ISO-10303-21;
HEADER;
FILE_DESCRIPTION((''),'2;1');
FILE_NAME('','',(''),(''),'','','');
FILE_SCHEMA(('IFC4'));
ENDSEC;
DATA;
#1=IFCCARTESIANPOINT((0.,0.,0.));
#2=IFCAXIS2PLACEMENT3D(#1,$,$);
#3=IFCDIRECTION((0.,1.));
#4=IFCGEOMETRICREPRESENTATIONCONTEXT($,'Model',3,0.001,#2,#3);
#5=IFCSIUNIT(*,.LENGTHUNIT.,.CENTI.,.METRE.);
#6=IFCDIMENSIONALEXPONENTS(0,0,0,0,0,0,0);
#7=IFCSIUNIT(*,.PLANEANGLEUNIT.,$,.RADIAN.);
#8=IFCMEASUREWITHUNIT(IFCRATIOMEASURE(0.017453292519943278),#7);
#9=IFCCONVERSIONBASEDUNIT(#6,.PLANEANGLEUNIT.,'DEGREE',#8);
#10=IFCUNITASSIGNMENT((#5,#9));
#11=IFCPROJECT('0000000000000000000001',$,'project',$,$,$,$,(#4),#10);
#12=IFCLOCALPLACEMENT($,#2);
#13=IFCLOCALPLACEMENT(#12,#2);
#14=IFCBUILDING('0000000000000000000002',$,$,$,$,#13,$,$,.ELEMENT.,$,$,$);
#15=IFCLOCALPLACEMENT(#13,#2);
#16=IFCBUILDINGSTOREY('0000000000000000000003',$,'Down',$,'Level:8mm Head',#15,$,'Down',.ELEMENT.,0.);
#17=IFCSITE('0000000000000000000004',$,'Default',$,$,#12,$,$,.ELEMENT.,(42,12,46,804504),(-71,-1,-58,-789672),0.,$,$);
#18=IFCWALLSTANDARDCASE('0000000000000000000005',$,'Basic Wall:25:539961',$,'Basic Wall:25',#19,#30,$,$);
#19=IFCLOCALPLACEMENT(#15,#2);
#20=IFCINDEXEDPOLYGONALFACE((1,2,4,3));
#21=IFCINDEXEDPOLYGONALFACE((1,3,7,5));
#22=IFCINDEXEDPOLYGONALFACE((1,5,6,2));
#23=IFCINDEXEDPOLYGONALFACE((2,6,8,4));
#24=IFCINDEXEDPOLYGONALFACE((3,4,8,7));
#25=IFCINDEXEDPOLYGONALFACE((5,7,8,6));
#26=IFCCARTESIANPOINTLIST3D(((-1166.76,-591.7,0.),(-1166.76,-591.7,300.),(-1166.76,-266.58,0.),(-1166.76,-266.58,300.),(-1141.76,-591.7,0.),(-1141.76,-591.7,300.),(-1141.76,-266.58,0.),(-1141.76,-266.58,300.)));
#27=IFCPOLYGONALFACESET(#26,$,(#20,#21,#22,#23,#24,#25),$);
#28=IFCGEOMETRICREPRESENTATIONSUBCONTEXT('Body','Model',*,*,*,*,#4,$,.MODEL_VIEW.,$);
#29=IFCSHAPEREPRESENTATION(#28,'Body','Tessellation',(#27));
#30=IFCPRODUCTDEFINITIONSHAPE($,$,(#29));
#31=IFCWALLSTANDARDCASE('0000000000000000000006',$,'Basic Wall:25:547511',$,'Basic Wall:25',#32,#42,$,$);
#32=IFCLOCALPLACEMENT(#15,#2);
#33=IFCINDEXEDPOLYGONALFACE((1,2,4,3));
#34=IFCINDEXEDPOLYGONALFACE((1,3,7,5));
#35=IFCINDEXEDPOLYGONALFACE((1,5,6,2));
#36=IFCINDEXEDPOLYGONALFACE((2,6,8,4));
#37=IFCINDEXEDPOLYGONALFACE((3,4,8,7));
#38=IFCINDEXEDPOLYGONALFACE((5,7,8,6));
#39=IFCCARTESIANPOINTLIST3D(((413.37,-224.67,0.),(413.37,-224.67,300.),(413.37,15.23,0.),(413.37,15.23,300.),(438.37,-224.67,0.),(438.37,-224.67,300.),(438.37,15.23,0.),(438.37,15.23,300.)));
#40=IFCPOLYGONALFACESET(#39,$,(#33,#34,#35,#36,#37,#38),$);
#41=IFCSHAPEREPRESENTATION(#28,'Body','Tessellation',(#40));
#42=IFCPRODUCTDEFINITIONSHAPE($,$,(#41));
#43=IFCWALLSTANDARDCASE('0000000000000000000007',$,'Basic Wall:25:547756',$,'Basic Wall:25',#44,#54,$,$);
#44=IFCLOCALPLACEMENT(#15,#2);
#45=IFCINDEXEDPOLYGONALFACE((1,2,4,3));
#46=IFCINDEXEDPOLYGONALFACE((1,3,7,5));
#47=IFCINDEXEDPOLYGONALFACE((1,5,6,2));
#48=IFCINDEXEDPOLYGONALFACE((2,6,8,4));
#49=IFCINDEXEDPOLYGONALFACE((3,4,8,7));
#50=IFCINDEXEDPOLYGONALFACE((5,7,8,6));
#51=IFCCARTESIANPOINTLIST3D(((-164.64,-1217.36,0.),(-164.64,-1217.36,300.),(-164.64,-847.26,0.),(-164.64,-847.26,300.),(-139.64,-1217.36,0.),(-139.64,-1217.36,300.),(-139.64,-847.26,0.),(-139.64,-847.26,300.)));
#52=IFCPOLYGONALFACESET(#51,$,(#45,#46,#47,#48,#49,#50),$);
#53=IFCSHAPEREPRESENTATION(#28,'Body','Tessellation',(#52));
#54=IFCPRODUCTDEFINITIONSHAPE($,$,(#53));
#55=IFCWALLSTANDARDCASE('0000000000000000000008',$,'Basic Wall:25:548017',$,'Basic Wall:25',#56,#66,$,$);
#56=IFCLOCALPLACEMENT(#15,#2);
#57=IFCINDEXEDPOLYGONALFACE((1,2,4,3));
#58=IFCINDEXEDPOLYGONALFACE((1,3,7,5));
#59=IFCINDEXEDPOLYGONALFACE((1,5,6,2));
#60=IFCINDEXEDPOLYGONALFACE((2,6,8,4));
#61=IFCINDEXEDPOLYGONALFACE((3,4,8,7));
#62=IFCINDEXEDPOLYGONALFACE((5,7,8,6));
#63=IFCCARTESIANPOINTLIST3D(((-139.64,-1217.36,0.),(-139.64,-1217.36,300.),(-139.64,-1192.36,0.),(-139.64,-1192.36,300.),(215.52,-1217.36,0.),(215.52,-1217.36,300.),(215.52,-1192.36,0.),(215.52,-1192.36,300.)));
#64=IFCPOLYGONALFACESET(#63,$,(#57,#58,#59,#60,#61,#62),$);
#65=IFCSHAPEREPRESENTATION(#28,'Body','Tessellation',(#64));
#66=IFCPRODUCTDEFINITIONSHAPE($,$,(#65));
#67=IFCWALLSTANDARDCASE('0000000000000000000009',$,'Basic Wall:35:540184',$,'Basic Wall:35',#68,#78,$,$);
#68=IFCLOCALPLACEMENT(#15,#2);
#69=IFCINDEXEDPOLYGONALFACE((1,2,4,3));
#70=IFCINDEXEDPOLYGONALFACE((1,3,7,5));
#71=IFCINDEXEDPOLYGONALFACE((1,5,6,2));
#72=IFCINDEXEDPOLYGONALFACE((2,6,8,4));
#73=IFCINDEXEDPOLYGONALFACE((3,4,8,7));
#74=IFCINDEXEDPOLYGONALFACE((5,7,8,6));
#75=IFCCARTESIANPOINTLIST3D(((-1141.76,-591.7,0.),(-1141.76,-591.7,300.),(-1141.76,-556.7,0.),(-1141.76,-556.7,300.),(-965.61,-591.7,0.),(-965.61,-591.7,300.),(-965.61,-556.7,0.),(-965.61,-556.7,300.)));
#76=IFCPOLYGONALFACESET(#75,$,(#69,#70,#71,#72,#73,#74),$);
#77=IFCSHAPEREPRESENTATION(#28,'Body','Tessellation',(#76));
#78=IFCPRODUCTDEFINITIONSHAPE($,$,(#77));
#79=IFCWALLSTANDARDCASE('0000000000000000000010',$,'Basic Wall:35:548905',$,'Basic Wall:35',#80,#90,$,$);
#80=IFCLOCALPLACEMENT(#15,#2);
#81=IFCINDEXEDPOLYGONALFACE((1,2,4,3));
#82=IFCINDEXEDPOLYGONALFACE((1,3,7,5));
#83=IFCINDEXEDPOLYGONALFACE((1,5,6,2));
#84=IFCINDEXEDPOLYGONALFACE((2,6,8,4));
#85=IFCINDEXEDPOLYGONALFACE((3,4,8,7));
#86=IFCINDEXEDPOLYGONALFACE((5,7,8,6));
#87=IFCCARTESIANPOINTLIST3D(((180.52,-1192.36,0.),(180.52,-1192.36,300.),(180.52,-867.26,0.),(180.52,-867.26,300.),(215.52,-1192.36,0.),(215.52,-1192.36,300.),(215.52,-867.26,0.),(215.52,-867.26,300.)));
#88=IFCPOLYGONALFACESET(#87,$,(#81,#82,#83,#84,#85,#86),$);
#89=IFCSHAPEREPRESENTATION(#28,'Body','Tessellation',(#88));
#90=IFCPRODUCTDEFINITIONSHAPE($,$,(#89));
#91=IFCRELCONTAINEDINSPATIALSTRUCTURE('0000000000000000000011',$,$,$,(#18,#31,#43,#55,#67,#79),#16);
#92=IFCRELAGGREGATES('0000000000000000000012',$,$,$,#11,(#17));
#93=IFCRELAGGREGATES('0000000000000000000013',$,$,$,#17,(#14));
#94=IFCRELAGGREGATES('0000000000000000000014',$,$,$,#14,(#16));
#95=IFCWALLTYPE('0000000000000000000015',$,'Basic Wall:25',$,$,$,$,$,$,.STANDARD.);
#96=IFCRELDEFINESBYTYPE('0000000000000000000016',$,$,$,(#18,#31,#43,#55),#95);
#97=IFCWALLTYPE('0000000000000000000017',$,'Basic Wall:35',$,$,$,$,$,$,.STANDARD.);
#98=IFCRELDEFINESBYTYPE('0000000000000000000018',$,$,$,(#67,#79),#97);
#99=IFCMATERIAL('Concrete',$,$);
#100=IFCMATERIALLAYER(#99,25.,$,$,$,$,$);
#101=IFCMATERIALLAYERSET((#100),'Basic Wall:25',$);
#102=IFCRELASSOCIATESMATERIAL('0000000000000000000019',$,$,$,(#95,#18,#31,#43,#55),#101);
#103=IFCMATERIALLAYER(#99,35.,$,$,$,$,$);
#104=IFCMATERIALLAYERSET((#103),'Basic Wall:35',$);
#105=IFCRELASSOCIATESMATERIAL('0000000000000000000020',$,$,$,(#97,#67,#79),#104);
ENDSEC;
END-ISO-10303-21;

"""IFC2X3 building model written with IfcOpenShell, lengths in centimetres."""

from ifc_helpers import new_model, entity, si_unit, converted_unit, direction, frame, frame_2d, origin, place, context, subcontext, project, spatial, rectangle, extrude, material, layer, layer_set, layer_usage, type_object, element, save


model = new_model("IFC2X3")

# Units and contexts
model_context = context("Model", 3, precision=0.001, world=origin(), true_north=direction((0.0, 1.0)))
body_context = subcontext(model_context, "Body", "Model", "MODEL_VIEW")
ifc_project = project(units=[si_unit("LENGTHUNIT", "METRE", prefix="CENTI"), converted_unit("PLANEANGLEUNIT", "DEGREE", entity("IfcRatioMeasure", 0.017453292519943278), si_unit("PLANEANGLEUNIT", "RADIAN"), dimensions=[0, 0, 0, 0, 0, 0, 0])], contexts=[model_context])

# Site, building, storey
site_placement = place(None, origin())
site = spatial("IfcSite", under=ifc_project, at=site_placement, Name="Default", CompositionType="ELEMENT", RefLatitude=(42, 12, 46, 804504), RefLongitude=(-71, -1, -58, -789672), RefElevation=0.0)
building_placement = place(site_placement, origin())
building = spatial("IfcBuilding", under=site, at=building_placement, CompositionType="ELEMENT")
storey_placement = place(building_placement, origin())
storey = spatial("IfcBuildingStorey", under=building, at=storey_placement, Name="Down", ObjectType="Level:8mm Head", LongName="Down", CompositionType="ELEMENT", Elevation=0.0)

# Shared definitions
ifc_material = material(Name="Concrete")

# Walls
ifc_layer_1 = layer(ifc_material, 25.0)
ifc_layer_set_1 = layer_set([ifc_layer_1], Name="Basic Wall:25")
ifc_layer_usage_1 = layer_usage(ifc_layer_set_1, "AXIS2", "POSITIVE", -12.5)
wall_type_1 = type_object("IfcWallType", Name="Basic Wall:25", PredefinedType="STANDARD", material=ifc_layer_set_1)
wall_1_placement = place(storey_placement, frame((-1154.26, -266.58, 0.0), z_axis=(0.0, 0.0, 1.0), x_axis=(0.0, -1.0, 0.0)))
element("IfcWallStandardCase", 1, at=wall_1_placement, inside=storey, type_object=wall_type_1, material=ifc_layer_usage_1, Name="Basic Wall:25:539961", ObjectType="Basic Wall:25", context=body_context, shape_type="SweptSolid", body=[
    extrude(rectangle(XDim=325.12, YDim=25.0, at=frame_2d((162.56, 0.0), x_axis=(-1.0, 0.0))), origin(), (0.0, 0.0, 1.0), 300.0),
])
ifc_layer_usage_2 = layer_usage(ifc_layer_set_1, "AXIS2", "POSITIVE", -12.5)
wall_2_placement = place(storey_placement, frame((425.87, -224.67, 0.0), z_axis=(0.0, 0.0, 1.0), x_axis=(0.0, 1.0, 0.0)))
element("IfcWallStandardCase", 2, at=wall_2_placement, inside=storey, type_object=wall_type_1, material=ifc_layer_usage_2, Name="Basic Wall:25:547511", ObjectType="Basic Wall:25", context=body_context, shape_type="SweptSolid", body=[
    extrude(rectangle(XDim=239.91, YDim=25.0, at=frame_2d((119.95, 0.0), x_axis=(-1.0, 0.0))), origin(), (0.0, 0.0, 1.0), 300.0),
])
ifc_layer_usage_3 = layer_usage(ifc_layer_set_1, "AXIS2", "POSITIVE", -12.5)
wall_3_placement = place(storey_placement, frame((-152.14, -847.26, 0.0), z_axis=(0.0, 0.0, 1.0), x_axis=(0.0, -1.0, 0.0)))
element("IfcWallStandardCase", 3, at=wall_3_placement, inside=storey, type_object=wall_type_1, material=ifc_layer_usage_3, Name="Basic Wall:25:547756", ObjectType="Basic Wall:25", context=body_context, shape_type="SweptSolid", body=[
    extrude(rectangle(XDim=370.1, YDim=25.0, at=frame_2d((185.05, 0.0), x_axis=(-1.0, 0.0))), origin(), (0.0, 0.0, 1.0), 300.0),
])
ifc_layer_usage_4 = layer_usage(ifc_layer_set_1, "AXIS2", "POSITIVE", -12.5)
wall_4_placement = place(storey_placement, frame((-139.64, -1204.86, 0.0)))
element("IfcWallStandardCase", 4, at=wall_4_placement, inside=storey, type_object=wall_type_1, material=ifc_layer_usage_4, Name="Basic Wall:25:548017", ObjectType="Basic Wall:25", context=body_context, shape_type="SweptSolid", body=[
    extrude(rectangle(XDim=355.16, YDim=25.0, at=frame_2d((177.58, 0.0), x_axis=(-1.0, 0.0))), origin(), (0.0, 0.0, 1.0), 300.0),
])
ifc_layer_2 = layer(ifc_material, 35.0)
ifc_layer_set_2 = layer_set([ifc_layer_2], Name="Basic Wall:35")
ifc_layer_usage_5 = layer_usage(ifc_layer_set_2, "AXIS2", "POSITIVE", -17.5)
wall_type_2 = type_object("IfcWallType", Name="Basic Wall:35", PredefinedType="STANDARD", material=ifc_layer_set_2)
wall_5_placement = place(storey_placement, frame((-1141.76, -574.2, 0.0)))
element("IfcWallStandardCase", 5, at=wall_5_placement, inside=storey, type_object=wall_type_2, material=ifc_layer_usage_5, Name="Basic Wall:35:540184", ObjectType="Basic Wall:35", context=body_context, shape_type="SweptSolid", body=[
    extrude(rectangle(XDim=176.14, YDim=35.0, at=frame_2d((88.07, 0.0), x_axis=(-1.0, 0.0))), origin(), (0.0, 0.0, 1.0), 300.0),
])
ifc_layer_usage_6 = layer_usage(ifc_layer_set_2, "AXIS2", "NEGATIVE", 17.5)
wall_6_placement = place(storey_placement, frame((198.02, -867.26, 0.0), z_axis=(0.0, 0.0, 1.0), x_axis=(0.0, -1.0, 0.0)))
element("IfcWallStandardCase", 6, at=wall_6_placement, inside=storey, type_object=wall_type_2, material=ifc_layer_usage_6, Name="Basic Wall:35:548905", ObjectType="Basic Wall:35", context=body_context, shape_type="SweptSolid", body=[
    extrude(rectangle(XDim=325.1, YDim=35.0, at=frame_2d((162.55, 0.0), x_axis=(-1.0, 0.0))), origin(), (0.0, 0.0, 1.0), 300.0),
])

save(model, "model.ifc")
